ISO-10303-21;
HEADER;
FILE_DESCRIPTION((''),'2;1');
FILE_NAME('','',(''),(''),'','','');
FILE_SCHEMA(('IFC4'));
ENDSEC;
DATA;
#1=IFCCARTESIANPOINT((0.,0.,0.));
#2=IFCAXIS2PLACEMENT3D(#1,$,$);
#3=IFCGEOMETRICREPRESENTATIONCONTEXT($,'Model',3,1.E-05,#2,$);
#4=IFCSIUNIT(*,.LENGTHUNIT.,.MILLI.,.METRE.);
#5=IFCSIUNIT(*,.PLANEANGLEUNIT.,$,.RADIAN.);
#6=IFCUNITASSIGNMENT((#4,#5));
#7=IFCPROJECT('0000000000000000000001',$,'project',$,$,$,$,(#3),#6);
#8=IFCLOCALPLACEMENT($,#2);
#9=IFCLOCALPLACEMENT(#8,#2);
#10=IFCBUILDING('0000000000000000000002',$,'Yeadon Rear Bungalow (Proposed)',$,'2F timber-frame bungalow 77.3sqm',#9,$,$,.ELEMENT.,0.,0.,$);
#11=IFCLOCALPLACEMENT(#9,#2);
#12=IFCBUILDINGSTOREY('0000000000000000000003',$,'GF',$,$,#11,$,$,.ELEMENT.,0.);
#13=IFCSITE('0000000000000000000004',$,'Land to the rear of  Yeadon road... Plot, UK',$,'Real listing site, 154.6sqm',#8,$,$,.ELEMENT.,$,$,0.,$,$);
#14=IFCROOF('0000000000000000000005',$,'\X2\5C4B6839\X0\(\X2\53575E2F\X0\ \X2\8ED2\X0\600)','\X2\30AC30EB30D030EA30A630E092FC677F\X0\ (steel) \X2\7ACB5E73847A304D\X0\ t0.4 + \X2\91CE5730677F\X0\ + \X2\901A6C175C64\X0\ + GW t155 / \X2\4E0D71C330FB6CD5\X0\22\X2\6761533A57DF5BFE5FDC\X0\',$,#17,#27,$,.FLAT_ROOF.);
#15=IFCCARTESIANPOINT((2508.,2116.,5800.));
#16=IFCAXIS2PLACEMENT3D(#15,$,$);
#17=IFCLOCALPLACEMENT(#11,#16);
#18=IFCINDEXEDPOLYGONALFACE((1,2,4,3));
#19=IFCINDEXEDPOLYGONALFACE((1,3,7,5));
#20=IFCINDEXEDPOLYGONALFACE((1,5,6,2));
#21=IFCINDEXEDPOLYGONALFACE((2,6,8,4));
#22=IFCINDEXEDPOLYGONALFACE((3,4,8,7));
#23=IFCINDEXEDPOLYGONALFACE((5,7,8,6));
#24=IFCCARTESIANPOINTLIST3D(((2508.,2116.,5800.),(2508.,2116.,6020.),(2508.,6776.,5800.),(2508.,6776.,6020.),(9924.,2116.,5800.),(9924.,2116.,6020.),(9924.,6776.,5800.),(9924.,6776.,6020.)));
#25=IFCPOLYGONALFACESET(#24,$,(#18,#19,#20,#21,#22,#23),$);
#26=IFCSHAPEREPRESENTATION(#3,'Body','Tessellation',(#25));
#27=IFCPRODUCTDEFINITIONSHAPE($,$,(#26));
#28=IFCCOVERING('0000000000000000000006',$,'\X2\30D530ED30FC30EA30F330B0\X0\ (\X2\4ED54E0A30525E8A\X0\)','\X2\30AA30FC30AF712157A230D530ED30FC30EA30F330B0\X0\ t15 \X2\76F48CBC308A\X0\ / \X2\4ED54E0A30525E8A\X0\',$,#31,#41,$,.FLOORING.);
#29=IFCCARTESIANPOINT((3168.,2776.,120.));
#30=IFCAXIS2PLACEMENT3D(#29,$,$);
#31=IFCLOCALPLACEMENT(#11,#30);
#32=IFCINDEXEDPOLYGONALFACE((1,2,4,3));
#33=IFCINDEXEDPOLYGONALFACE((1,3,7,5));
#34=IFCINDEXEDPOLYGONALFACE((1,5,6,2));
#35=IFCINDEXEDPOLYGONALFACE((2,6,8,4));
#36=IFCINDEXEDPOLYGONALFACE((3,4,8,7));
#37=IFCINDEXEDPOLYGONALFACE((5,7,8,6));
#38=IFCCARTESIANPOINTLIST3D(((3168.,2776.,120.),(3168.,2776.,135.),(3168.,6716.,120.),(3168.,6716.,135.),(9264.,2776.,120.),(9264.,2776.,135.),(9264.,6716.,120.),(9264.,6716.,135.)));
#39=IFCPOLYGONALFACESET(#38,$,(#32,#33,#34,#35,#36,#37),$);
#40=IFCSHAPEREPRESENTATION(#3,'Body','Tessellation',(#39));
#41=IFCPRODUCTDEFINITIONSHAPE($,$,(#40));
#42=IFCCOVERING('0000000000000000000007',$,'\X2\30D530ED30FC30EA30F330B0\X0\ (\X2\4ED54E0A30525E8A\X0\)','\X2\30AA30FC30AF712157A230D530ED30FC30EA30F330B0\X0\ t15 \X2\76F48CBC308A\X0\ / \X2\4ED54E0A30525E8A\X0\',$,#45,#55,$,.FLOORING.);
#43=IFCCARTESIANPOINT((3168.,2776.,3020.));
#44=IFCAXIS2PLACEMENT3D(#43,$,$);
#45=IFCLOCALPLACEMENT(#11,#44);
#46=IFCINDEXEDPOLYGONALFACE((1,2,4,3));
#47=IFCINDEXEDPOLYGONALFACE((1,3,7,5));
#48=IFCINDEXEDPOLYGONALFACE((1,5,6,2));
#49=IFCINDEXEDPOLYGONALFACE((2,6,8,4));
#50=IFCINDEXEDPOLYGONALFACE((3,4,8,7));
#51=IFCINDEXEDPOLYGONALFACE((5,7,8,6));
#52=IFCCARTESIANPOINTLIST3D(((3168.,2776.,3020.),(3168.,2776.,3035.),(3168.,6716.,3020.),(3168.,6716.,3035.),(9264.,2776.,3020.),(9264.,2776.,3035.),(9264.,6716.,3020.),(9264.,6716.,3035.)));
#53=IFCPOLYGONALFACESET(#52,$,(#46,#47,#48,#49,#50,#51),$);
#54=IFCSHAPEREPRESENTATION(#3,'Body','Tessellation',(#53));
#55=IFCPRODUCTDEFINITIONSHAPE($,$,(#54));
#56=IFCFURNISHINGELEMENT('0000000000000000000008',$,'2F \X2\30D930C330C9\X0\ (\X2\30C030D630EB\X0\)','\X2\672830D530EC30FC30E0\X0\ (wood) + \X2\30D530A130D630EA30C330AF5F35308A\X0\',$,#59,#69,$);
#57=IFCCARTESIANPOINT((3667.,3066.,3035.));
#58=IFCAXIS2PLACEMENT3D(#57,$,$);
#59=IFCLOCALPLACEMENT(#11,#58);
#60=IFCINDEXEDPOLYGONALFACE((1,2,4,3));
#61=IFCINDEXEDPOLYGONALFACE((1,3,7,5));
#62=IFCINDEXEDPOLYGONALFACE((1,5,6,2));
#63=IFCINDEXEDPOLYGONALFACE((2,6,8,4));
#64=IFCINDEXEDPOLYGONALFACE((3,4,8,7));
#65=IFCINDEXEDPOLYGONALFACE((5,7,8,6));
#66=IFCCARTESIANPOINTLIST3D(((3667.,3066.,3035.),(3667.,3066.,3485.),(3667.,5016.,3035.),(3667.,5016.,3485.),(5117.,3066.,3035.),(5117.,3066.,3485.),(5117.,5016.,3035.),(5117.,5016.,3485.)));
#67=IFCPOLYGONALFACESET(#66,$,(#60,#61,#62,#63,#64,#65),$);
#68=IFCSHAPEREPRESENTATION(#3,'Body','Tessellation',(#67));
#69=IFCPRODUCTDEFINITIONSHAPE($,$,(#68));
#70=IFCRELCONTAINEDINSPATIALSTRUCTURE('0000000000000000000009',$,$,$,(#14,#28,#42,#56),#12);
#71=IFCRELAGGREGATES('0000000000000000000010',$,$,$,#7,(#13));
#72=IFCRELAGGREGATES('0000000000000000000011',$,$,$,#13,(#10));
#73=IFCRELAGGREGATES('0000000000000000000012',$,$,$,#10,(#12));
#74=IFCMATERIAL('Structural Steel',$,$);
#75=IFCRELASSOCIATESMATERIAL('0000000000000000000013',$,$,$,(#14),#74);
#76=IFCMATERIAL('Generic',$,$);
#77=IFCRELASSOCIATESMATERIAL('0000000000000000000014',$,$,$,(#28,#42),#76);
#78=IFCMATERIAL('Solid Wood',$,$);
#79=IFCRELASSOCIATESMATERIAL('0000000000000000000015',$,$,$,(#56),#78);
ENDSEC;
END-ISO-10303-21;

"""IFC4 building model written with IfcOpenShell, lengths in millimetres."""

from ifc_helpers import new_model, si_unit, frame, frame_2d, origin, place, context, project, spatial, rectangle, extrude, material, element, save


model = new_model("IFC4")

# Units and contexts
model_context = context("Model", 3, precision=1e-05, world=origin())
ifc_project = project(units=[si_unit("LENGTHUNIT", "METRE", prefix="MILLI"), si_unit("PLANEANGLEUNIT", "RADIAN")], contexts=[model_context])

# Site, building, storey
site_placement = place(None, origin())
site = spatial("IfcSite", under=ifc_project, at=site_placement, Name="Land to the rear of  Yeadon road... Plot, UK", ObjectType="Real listing site, 154.6sqm", CompositionType="ELEMENT", RefElevation=0.0)
building_placement = place(site_placement, origin())
building = spatial("IfcBuilding", under=site, at=building_placement, Name="Yeadon Rear Bungalow (Proposed)", ObjectType="2F timber-frame bungalow 77.3sqm", CompositionType="ELEMENT", ElevationOfRefHeight=0.0, ElevationOfTerrain=0.0)
storey_placement = place(building_placement, origin())
storey = spatial("IfcBuildingStorey", under=building, at=storey_placement, Name="GF", CompositionType="ELEMENT", Elevation=0.0)

# Shared definitions
ifc_material_1 = material(Name="Solid Wood")

# Roof
ifc_material_2 = material(Name="Structural Steel")
for number, where, name in (
    (1, (2508.0, 2116.0, 5800.0), "屋根(南帯 軒600)"),
):
    element("IfcRoof", number, at=place(storey_placement, frame(where)), inside=storey, material=ifc_material_2, Name=name, Description="ガルバリウム鋼板 (steel) 立平葺き t0.4 + 野地板 + 通気層 + GW t155 / 不燃・法22条区域対応", PredefinedType="FLAT_ROOF", context=model_context, shape_type="SweptSolid", body=[
        extrude(rectangle(XDim=7416.0, YDim=4660.0, at=frame_2d((3708.0, 2330.0))), frame((2508.0, 2116.0, 5800.0)), (0.0, 0.0, 1.0), 220.0),
    ])

# Coverings
ifc_material_3 = material(Name="Generic")
covering_1_placement = place(storey_placement, frame((3168.0, 2776.0, 120.0)))
element("IfcCovering", 2, at=covering_1_placement, inside=storey, material=ifc_material_3, Name="フローリング (仕上げ床)", Description="オーク無垢フローリング t15 直貼り / 仕上げ床", PredefinedType="FLOORING", context=model_context, shape_type="SweptSolid", body=[
    extrude(rectangle(XDim=6096.0, YDim=3940.0, at=frame_2d((3048.0, 1970.0))), frame((3168.0, 2776.0, 120.0)), (0.0, 0.0, 1.0), 15.0),
])
covering_2_placement = place(storey_placement, frame((3168.0, 2776.0, 3020.0)))
element("IfcCovering", 3, at=covering_2_placement, inside=storey, material=ifc_material_3, Name="フローリング (仕上げ床)", Description="オーク無垢フローリング t15 直貼り / 仕上げ床", PredefinedType="FLOORING", context=model_context, shape_type="SweptSolid", body=[
    extrude(rectangle(XDim=6096.0, YDim=3940.0, at=frame_2d((3048.0, 1970.0))), frame((3168.0, 2776.0, 3020.0)), (0.0, 0.0, 1.0), 15.0),
])

# Furnishing element
furnishing_placement = place(storey_placement, frame((3667.0, 3066.0, 3035.0)))
element("IfcFurnishingElement", 4, at=furnishing_placement, inside=storey, material=ifc_material_1, Name="2F ベッド (ダブル)", Description="木フレーム (wood) + ファブリック張り", context=model_context, shape_type="SweptSolid", body=[
    extrude(rectangle(XDim=1450.0, YDim=1950.0, at=frame_2d((725.0, 975.0))), frame((3667.0, 3066.0, 3035.0)), (0.0, 0.0, 1.0), 450.0),
])

save(model, "model.ifc")
